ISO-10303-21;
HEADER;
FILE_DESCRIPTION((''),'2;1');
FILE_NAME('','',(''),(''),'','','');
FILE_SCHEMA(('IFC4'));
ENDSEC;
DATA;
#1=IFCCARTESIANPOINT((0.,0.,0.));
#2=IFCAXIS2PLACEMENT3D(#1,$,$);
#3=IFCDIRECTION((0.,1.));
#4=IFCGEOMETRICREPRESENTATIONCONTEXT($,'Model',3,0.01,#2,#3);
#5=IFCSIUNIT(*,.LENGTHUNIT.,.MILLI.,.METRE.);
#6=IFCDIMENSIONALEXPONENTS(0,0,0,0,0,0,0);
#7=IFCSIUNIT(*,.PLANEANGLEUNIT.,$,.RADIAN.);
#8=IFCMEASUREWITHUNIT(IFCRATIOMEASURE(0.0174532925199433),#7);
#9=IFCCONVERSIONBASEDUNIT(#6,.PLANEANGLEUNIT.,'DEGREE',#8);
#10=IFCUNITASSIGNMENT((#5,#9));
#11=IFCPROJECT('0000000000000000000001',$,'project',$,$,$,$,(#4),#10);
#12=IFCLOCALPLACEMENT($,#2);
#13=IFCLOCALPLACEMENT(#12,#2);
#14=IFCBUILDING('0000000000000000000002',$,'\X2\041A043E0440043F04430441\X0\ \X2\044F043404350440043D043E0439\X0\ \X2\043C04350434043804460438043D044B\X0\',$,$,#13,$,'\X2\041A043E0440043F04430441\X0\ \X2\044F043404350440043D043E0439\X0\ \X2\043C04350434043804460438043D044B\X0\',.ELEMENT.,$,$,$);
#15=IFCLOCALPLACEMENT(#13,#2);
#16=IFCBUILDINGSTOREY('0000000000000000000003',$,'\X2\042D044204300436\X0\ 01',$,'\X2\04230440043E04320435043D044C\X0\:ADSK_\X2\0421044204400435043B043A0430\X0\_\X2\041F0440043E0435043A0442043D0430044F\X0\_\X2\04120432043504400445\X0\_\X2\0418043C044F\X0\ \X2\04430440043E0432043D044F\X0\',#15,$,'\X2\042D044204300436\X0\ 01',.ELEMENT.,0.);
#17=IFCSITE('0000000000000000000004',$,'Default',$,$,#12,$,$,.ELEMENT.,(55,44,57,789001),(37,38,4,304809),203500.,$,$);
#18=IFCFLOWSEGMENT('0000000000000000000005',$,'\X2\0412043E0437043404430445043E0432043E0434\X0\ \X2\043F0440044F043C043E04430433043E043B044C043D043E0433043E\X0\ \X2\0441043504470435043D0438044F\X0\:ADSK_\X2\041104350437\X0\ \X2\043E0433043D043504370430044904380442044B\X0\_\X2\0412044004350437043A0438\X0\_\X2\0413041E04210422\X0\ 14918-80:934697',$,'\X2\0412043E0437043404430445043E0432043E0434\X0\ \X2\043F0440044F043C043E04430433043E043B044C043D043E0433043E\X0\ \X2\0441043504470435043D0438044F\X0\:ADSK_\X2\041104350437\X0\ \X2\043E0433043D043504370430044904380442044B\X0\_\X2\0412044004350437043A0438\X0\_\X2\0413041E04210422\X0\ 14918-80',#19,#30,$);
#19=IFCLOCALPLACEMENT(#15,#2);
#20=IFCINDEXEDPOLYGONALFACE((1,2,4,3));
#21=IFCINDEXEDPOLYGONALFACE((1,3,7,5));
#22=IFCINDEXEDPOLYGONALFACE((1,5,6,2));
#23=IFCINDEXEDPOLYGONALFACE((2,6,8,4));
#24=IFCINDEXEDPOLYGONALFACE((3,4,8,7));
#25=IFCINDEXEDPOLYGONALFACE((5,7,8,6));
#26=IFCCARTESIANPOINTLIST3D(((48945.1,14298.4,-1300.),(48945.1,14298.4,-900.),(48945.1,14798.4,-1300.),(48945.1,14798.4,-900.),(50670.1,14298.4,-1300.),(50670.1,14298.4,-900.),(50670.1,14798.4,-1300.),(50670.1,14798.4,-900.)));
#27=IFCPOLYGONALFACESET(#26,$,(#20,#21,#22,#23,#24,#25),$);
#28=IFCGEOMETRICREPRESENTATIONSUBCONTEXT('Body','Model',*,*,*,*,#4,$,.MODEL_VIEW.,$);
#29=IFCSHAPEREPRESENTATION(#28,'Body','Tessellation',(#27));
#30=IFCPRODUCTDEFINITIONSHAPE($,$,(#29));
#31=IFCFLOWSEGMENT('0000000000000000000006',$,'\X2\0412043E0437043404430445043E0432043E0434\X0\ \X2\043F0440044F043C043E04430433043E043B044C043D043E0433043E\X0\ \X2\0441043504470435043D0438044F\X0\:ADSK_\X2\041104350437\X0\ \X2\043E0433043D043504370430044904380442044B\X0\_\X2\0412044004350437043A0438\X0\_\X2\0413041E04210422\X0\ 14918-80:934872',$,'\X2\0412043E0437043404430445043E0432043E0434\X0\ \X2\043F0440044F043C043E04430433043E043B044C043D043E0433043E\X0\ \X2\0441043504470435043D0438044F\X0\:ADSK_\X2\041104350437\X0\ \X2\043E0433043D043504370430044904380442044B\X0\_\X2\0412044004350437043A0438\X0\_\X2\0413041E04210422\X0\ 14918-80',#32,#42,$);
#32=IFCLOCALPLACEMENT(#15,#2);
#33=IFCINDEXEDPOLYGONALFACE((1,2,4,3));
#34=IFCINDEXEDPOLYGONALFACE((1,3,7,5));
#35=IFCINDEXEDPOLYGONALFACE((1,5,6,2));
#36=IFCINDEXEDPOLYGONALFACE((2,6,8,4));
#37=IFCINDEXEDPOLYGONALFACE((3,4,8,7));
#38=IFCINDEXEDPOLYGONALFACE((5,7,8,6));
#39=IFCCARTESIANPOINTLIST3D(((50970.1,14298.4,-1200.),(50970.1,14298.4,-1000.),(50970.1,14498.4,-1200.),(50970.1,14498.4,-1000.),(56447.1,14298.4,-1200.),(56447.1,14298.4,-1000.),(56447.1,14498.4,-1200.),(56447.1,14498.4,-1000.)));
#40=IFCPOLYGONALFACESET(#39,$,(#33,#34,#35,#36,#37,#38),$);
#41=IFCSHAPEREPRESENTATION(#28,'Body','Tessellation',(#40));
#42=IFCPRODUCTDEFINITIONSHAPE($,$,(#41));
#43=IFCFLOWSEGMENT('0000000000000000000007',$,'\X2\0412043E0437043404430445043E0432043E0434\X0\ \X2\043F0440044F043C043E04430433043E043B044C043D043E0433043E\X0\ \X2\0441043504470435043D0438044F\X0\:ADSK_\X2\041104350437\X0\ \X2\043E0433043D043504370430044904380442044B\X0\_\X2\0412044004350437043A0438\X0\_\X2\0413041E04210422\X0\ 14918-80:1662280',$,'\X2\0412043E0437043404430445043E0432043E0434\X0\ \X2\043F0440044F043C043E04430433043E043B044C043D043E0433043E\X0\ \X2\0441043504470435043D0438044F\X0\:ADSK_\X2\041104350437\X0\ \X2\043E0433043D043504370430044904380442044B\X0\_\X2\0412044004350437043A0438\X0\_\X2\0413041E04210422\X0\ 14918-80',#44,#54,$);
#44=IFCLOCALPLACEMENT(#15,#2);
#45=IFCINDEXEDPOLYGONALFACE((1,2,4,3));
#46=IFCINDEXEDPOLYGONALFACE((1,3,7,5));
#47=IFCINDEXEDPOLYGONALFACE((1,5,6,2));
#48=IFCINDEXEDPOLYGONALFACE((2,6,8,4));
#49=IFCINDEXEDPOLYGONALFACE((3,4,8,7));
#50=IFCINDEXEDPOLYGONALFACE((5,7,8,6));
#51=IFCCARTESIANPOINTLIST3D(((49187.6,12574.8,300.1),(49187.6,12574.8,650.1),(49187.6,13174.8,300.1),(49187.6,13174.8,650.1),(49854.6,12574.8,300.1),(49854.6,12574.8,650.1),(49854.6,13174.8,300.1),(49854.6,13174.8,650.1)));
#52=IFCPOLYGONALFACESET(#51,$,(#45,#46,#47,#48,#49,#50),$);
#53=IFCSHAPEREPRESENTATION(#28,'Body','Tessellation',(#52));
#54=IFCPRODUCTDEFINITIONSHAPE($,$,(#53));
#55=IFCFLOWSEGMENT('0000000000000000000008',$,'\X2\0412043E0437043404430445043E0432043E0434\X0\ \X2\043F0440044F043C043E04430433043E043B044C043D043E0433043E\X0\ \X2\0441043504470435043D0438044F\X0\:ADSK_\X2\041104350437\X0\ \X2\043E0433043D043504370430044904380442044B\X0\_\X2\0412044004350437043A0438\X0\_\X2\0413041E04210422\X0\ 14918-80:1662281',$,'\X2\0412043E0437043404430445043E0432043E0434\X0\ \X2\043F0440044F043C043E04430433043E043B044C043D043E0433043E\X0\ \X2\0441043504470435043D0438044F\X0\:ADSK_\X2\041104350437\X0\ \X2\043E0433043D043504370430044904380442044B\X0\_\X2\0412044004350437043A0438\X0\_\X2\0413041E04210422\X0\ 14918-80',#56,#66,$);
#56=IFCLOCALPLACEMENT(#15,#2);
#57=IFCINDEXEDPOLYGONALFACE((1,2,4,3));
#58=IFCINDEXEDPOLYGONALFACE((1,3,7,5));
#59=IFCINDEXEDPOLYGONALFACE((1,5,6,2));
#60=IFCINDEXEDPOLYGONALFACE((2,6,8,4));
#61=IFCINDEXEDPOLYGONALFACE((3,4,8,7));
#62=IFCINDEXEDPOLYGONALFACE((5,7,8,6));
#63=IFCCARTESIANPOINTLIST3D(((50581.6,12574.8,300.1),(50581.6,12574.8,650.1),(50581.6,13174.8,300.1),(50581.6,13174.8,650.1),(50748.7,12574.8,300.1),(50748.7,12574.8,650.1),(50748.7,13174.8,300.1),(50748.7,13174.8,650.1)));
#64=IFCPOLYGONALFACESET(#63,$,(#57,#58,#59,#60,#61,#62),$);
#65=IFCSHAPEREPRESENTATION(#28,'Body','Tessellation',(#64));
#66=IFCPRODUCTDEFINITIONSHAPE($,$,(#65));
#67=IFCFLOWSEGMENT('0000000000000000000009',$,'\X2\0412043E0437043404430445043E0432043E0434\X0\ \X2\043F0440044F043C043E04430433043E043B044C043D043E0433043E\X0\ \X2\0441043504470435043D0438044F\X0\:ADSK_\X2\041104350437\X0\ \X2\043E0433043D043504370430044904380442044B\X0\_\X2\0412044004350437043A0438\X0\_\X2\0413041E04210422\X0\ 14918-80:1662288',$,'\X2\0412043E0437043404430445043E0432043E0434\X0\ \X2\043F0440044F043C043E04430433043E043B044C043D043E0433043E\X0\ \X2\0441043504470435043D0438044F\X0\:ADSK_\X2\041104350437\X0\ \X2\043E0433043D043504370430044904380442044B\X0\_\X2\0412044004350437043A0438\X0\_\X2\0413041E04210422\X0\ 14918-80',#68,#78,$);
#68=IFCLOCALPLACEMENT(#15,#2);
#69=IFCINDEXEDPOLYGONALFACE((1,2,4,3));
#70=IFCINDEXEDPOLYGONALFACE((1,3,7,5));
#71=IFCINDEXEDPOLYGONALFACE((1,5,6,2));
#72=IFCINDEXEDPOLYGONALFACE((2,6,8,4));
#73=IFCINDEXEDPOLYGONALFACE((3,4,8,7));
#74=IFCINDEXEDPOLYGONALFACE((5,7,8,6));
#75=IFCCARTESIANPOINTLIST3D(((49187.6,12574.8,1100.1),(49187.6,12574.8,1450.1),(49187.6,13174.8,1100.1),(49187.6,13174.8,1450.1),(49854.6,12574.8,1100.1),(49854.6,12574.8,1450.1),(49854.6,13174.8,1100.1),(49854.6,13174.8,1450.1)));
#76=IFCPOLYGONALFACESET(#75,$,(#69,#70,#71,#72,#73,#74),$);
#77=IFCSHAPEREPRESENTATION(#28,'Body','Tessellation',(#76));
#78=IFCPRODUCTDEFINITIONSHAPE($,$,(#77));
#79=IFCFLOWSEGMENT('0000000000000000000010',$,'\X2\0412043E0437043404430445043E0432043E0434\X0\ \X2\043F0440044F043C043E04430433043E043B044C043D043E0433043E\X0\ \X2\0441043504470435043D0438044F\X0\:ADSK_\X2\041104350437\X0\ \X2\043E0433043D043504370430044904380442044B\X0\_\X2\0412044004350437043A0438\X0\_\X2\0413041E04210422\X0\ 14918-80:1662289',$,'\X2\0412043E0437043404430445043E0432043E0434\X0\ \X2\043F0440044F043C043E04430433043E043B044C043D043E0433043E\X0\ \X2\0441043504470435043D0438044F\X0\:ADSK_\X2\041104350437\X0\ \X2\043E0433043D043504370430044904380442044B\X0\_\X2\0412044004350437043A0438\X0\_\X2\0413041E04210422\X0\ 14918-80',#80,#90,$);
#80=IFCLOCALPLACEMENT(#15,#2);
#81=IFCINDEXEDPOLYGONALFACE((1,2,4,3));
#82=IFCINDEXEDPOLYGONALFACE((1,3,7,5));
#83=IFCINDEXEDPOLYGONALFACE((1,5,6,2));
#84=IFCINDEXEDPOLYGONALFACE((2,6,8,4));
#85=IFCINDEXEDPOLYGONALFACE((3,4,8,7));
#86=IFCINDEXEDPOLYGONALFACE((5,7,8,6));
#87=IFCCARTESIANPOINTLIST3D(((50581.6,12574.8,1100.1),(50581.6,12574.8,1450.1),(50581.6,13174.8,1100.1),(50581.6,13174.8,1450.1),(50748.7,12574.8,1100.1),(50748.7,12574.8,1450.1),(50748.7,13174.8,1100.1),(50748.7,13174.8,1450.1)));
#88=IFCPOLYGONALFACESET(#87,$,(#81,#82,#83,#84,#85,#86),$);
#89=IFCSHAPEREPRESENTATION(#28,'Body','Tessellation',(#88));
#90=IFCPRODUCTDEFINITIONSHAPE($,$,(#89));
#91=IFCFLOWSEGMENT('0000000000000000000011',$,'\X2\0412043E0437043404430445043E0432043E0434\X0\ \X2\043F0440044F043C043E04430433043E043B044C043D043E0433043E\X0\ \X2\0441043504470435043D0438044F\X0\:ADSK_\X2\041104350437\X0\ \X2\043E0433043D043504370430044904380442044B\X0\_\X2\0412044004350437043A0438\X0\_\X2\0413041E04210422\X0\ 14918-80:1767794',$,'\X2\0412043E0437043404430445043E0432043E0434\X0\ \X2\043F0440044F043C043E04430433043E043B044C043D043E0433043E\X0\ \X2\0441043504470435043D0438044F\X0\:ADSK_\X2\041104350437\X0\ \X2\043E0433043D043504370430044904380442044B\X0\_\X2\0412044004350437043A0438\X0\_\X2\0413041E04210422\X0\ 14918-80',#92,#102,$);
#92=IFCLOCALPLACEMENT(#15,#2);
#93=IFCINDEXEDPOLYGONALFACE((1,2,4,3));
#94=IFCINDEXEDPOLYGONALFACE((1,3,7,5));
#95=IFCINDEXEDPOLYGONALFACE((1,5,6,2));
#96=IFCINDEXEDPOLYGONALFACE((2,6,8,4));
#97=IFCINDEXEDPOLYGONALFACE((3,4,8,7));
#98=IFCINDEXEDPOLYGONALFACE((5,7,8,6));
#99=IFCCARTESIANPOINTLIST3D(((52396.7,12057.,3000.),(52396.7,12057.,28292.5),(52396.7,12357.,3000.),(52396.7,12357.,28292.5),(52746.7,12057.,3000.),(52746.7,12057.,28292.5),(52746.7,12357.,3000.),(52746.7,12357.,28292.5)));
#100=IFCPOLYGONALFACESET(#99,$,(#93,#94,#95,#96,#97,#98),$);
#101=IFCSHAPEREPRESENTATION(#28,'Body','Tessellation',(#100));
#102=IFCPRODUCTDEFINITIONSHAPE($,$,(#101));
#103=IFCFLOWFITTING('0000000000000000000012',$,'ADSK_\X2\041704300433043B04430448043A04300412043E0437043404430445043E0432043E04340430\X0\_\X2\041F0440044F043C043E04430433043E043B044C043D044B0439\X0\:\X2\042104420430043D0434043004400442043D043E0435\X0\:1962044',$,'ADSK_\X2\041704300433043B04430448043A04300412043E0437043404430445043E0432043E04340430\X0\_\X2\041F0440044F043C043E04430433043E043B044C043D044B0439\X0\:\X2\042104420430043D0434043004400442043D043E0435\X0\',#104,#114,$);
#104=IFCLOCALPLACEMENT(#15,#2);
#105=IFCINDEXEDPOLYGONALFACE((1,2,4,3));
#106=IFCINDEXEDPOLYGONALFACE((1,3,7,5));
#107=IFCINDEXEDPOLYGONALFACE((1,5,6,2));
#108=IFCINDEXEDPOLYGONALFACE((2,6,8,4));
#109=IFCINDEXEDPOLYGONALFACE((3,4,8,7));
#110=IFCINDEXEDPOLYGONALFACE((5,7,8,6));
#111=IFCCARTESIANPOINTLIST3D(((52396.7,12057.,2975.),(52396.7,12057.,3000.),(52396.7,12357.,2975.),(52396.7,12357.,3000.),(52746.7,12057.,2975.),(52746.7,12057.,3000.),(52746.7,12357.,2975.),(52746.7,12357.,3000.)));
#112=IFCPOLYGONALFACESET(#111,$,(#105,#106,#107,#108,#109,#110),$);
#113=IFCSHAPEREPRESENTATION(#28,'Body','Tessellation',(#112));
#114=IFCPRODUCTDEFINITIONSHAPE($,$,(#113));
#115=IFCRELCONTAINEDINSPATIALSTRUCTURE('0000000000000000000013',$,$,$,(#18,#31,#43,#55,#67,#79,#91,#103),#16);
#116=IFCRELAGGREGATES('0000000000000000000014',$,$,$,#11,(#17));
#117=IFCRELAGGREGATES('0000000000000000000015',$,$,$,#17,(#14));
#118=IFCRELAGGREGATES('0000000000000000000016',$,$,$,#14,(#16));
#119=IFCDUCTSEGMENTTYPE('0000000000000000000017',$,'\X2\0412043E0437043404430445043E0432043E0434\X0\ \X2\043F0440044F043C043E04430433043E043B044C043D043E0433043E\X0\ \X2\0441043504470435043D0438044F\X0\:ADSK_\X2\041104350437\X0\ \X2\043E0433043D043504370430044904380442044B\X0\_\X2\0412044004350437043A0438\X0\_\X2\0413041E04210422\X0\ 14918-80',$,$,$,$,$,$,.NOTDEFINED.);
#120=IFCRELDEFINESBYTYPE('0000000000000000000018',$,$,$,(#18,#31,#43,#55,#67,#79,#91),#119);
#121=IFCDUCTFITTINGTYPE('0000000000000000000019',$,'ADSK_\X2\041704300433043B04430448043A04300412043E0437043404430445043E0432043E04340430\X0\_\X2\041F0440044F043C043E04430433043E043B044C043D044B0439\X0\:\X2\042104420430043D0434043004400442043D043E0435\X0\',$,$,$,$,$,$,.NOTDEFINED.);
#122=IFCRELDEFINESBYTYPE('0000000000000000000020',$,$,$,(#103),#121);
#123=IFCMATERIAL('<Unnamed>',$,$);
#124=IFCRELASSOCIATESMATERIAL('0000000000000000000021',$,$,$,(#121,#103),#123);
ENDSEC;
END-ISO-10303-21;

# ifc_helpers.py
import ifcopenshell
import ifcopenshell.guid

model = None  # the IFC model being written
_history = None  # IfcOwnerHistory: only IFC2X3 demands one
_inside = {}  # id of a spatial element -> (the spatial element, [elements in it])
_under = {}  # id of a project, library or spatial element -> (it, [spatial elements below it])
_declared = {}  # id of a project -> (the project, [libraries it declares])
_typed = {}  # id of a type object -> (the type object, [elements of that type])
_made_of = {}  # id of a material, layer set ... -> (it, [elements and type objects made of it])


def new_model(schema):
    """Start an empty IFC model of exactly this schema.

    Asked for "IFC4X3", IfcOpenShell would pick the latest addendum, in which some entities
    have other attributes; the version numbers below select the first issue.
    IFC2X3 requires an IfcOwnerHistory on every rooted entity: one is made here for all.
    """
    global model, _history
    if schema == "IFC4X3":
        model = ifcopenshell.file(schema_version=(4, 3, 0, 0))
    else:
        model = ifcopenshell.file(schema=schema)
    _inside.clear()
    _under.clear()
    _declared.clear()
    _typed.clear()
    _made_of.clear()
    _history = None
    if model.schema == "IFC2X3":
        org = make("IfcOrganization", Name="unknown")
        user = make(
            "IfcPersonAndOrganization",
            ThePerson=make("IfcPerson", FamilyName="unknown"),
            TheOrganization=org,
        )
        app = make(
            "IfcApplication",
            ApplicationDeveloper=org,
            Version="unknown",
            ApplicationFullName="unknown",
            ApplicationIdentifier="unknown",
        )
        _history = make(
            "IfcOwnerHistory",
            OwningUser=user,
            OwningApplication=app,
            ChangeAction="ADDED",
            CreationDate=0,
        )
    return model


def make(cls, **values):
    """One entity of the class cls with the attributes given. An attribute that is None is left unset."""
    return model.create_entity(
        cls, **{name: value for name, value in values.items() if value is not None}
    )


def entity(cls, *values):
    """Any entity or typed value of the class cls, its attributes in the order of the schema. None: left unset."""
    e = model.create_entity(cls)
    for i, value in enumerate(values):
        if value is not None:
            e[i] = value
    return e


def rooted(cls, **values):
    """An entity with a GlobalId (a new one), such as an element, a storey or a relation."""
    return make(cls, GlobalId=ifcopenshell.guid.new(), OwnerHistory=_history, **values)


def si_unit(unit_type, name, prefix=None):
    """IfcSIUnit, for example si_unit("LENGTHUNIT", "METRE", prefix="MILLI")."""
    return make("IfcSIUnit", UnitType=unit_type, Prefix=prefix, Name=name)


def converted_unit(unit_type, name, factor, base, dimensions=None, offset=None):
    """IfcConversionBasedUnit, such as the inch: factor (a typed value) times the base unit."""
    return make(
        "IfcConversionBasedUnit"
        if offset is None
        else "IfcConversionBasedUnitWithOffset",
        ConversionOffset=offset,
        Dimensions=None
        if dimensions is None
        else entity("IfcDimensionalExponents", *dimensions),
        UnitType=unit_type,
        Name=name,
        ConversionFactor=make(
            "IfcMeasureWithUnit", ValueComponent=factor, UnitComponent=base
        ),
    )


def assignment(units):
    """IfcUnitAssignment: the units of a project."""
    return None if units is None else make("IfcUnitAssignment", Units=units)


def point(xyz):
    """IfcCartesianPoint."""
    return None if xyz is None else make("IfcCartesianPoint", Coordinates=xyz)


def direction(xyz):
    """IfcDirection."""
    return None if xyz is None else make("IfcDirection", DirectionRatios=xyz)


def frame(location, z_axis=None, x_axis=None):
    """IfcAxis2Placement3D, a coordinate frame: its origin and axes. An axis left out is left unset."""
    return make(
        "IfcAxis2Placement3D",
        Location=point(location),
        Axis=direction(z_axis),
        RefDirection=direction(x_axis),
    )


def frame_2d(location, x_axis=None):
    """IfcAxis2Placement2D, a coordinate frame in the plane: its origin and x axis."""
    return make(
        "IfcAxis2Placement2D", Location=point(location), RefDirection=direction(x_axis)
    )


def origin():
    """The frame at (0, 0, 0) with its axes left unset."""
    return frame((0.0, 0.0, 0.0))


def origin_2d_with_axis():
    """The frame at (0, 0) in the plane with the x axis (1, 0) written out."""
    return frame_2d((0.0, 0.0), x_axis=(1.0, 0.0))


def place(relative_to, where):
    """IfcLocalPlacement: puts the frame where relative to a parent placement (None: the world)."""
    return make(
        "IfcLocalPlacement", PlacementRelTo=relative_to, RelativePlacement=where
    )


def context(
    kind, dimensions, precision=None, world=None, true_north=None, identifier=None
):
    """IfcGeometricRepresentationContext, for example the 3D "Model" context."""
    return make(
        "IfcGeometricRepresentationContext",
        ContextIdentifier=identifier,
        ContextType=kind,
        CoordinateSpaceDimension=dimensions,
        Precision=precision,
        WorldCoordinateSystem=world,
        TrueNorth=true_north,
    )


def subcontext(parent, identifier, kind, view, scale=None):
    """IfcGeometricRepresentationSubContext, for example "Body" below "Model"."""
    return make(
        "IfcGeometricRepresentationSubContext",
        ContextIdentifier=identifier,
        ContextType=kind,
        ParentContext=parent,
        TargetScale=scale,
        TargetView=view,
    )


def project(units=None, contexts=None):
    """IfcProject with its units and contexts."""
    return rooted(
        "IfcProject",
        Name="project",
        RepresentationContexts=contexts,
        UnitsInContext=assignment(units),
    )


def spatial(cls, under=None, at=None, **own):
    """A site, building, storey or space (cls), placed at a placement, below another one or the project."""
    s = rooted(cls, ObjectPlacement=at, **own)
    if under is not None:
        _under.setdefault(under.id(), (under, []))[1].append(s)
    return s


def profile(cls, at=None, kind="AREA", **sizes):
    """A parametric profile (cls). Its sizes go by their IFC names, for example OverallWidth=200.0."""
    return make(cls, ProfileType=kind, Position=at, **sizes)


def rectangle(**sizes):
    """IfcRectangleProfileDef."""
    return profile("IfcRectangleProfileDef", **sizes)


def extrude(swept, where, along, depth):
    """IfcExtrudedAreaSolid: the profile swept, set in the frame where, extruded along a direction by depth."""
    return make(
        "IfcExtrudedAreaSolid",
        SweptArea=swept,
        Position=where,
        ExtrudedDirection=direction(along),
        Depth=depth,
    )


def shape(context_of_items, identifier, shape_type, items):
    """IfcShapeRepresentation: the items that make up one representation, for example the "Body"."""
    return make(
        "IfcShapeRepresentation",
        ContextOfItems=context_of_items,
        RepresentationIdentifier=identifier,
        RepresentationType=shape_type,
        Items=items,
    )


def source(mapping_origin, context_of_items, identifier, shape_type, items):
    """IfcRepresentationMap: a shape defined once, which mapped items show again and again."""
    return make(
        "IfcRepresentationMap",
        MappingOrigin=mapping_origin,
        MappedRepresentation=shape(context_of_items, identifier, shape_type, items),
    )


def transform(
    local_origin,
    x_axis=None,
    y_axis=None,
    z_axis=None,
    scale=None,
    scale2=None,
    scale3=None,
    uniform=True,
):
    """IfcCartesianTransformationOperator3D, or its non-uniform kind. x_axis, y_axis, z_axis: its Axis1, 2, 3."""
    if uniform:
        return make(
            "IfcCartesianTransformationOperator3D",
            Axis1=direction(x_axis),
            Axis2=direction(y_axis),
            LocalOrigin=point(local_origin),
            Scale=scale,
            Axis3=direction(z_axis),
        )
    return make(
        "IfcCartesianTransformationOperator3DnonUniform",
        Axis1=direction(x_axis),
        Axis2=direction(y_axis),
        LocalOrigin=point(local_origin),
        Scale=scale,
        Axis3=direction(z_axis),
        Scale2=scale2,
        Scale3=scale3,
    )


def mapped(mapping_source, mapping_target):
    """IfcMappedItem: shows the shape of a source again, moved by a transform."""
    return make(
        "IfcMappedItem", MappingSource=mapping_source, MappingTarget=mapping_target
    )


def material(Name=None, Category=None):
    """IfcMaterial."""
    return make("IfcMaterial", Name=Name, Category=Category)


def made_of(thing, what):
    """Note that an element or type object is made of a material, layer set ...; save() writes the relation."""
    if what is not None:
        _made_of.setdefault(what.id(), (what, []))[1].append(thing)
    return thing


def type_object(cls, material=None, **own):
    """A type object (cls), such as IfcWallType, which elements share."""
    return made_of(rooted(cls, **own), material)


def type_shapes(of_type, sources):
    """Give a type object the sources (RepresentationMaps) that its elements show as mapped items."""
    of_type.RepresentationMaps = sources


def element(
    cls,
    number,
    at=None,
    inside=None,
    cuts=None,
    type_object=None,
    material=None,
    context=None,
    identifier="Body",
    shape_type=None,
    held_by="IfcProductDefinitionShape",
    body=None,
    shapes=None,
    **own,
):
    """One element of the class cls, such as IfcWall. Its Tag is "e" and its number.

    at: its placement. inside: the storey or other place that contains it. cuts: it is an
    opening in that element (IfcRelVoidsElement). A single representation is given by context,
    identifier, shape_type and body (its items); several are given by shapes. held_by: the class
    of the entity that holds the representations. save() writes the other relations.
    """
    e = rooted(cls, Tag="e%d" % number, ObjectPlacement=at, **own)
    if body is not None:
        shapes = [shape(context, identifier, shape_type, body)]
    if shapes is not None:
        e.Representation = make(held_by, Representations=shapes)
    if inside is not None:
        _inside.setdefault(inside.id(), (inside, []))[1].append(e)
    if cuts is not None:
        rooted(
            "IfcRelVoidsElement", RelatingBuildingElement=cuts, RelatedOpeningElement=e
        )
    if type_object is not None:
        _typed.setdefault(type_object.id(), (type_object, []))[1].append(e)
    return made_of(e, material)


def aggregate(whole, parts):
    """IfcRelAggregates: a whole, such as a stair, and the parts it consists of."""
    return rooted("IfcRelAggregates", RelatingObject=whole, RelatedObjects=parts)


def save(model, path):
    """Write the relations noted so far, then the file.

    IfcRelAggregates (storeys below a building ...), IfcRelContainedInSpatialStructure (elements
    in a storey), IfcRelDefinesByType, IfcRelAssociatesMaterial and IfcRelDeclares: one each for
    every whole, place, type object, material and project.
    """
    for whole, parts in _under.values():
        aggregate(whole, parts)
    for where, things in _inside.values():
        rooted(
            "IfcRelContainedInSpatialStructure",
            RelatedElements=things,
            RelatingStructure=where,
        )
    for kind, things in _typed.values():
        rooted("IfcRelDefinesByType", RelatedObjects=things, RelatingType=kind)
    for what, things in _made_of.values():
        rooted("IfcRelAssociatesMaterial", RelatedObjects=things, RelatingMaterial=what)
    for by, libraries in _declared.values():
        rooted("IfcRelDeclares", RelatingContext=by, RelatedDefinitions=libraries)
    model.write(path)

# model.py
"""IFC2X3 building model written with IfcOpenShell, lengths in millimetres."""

from ifc_helpers import new_model, entity, si_unit, converted_unit, direction, frame, origin, origin_2d_with_axis, place, context, subcontext, project, spatial, rectangle, extrude, source, transform, mapped, material, type_object, type_shapes, element, save


model = new_model("IFC2X3")

# Units and contexts
model_context = context("Model", 3, precision=0.01, world=origin(), true_north=direction((0.0, 1.0)))
body_context = subcontext(model_context, "Body", "Model", "MODEL_VIEW")
ifc_project = project(units=[si_unit("LENGTHUNIT", "METRE", prefix="MILLI"), converted_unit("PLANEANGLEUNIT", "DEGREE", entity("IfcRatioMeasure", 0.0174532925199433), si_unit("PLANEANGLEUNIT", "RADIAN"), dimensions=[0, 0, 0, 0, 0, 0, 0])], contexts=[model_context])

# Site, building, storey
site_placement = place(None, origin())
site = spatial("IfcSite", under=ifc_project, at=site_placement, Name="Default", CompositionType="ELEMENT", RefLatitude=(55, 44, 57, 789001), RefLongitude=(37, 38, 4, 304809), RefElevation=203500.0)
building_placement = place(site_placement, origin())
building = spatial("IfcBuilding", under=site, at=building_placement, Name="Корпус ядерной медицины", LongName="Корпус ядерной медицины", CompositionType="ELEMENT")
storey_placement = place(building_placement, origin())
storey = spatial("IfcBuildingStorey", under=building, at=storey_placement, Name="Этаж 01", ObjectType="Уровень:ADSK_Стрелка_Проектная_Вверх_Имя уровня", LongName="Этаж 01", CompositionType="ELEMENT", Elevation=0.0)

# Flow segments
duct_segment_type_1 = type_object("IfcDuctSegmentType", Name="Воздуховод прямоугольного сечения:ADSK_Без огнезащиты_Врезки_ГОСТ 14918-80", PredefinedType="NOTDEFINED")
flow_segment_1_placement = place(storey_placement, frame((48945.1, 14298.4, -1300.0)))
element("IfcFlowSegment", 1, at=flow_segment_1_placement, inside=storey, type_object=duct_segment_type_1, Name="Воздуховод прямоугольного сечения:ADSK_Без огнезащиты_Врезки_ГОСТ 14918-80:934697", ObjectType="Воздуховод прямоугольного сечения:ADSK_Без огнезащиты_Врезки_ГОСТ 14918-80", context=body_context, shape_type="SweptSolid", body=[
    extrude(rectangle(XDim=1725.0, YDim=500.0, at=origin_2d_with_axis()), frame((862.5, 250.0, 0.0)), (0.0, 0.0, 1.0), 400.0),
])
flow_segment_2_placement = place(storey_placement, frame((50970.1, 14298.4, -1200.0)))
element("IfcFlowSegment", 2, at=flow_segment_2_placement, inside=storey, type_object=duct_segment_type_1, Name="Воздуховод прямоугольного сечения:ADSK_Без огнезащиты_Врезки_ГОСТ 14918-80:934872", ObjectType="Воздуховод прямоугольного сечения:ADSK_Без огнезащиты_Врезки_ГОСТ 14918-80", context=body_context, shape_type="SweptSolid", body=[
    extrude(rectangle(XDim=5477.0, YDim=200.0, at=origin_2d_with_axis()), frame((2738.5, 100.0, 0.0), z_axis=(0.0, 0.0, 1.0), x_axis=(-1.0, 0.0, 0.0)), (0.0, 0.0, 1.0), 200.0),
])
flow_segment_3_placement = place(storey_placement, frame((49187.6, 12574.8, 300.1)))
element("IfcFlowSegment", 3, at=flow_segment_3_placement, inside=storey, type_object=duct_segment_type_1, Name="Воздуховод прямоугольного сечения:ADSK_Без огнезащиты_Врезки_ГОСТ 14918-80:1662280", ObjectType="Воздуховод прямоугольного сечения:ADSK_Без огнезащиты_Врезки_ГОСТ 14918-80", context=body_context, shape_type="SweptSolid", body=[
    extrude(rectangle(XDim=667.0, YDim=600.0, at=origin_2d_with_axis()), frame((333.5, 300.0, 0.0), z_axis=(0.0, 0.0, 1.0), x_axis=(-1.0, 0.0, 0.0)), (0.0, 0.0, 1.0), 350.0),
])
flow_segment_4_placement = place(storey_placement, frame((50581.6, 12574.8, 300.1)))
element("IfcFlowSegment", 4, at=flow_segment_4_placement, inside=storey, type_object=duct_segment_type_1, Name="Воздуховод прямоугольного сечения:ADSK_Без огнезащиты_Врезки_ГОСТ 14918-80:1662281", ObjectType="Воздуховод прямоугольного сечения:ADSK_Без огнезащиты_Врезки_ГОСТ 14918-80", context=body_context, shape_type="SweptSolid", body=[
    extrude(rectangle(XDim=167.1, YDim=600.0, at=origin_2d_with_axis()), frame((83.6, 300.0, 0.0)), (0.0, 0.0, 1.0), 350.0),
])
flow_segment_5_placement = place(storey_placement, frame((49187.6, 12574.8, 1100.1)))
element("IfcFlowSegment", 5, at=flow_segment_5_placement, inside=storey, type_object=duct_segment_type_1, Name="Воздуховод прямоугольного сечения:ADSK_Без огнезащиты_Врезки_ГОСТ 14918-80:1662288", ObjectType="Воздуховод прямоугольного сечения:ADSK_Без огнезащиты_Врезки_ГОСТ 14918-80", context=body_context, shape_type="SweptSolid", body=[
    extrude(rectangle(XDim=667.0, YDim=600.0, at=origin_2d_with_axis()), frame((333.5, 300.0, 0.0), z_axis=(0.0, 0.0, 1.0), x_axis=(-1.0, 0.0, 0.0)), (0.0, 0.0, 1.0), 350.0),
])
flow_segment_6_placement = place(storey_placement, frame((50581.6, 12574.8, 1100.1)))
element("IfcFlowSegment", 6, at=flow_segment_6_placement, inside=storey, type_object=duct_segment_type_1, Name="Воздуховод прямоугольного сечения:ADSK_Без огнезащиты_Врезки_ГОСТ 14918-80:1662289", ObjectType="Воздуховод прямоугольного сечения:ADSK_Без огнезащиты_Врезки_ГОСТ 14918-80", context=body_context, shape_type="SweptSolid", body=[
    extrude(rectangle(XDim=167.1, YDim=600.0, at=origin_2d_with_axis()), frame((83.6, 300.0, 0.0)), (0.0, 0.0, 1.0), 350.0),
])
flow_segment_7_placement = place(storey_placement, frame((52396.7, 12057.0, 3000.0)))
element("IfcFlowSegment", 7, at=flow_segment_7_placement, inside=storey, type_object=duct_segment_type_1, Name="Воздуховод прямоугольного сечения:ADSK_Без огнезащиты_Врезки_ГОСТ 14918-80:1767794", ObjectType="Воздуховод прямоугольного сечения:ADSK_Без огнезащиты_Врезки_ГОСТ 14918-80", context=body_context, shape_type="SweptSolid", body=[
    extrude(rectangle(XDim=300.0, YDim=350.0, at=origin_2d_with_axis()), frame((175.0, 150.0, 0.0), z_axis=(0.0, 0.0, 1.0), x_axis=(0.0, -1.0, 0.0)), (0.0, 0.0, 1.0), 25292.5),
])

# Flow fitting
ifc_material = material(Name="<Unnamed>")
duct_fitting_type = type_object("IfcDuctFittingType", Name="ADSK_ЗаглушкаВоздуховода_Прямоугольный:Стандартное", PredefinedType="NOTDEFINED", material=ifc_material)
shared_shape = source(origin(), body_context, "Body", "SweptSolid", [
    extrude(rectangle(XDim=25.0, YDim=300.0, at=origin_2d_with_axis()), frame((12.5, 0.0, -175.0)), (0.0, 0.0, 1.0), 350.0),
])
type_shapes(duct_fitting_type, [shared_shape])
flow_fitting_placement = place(storey_placement, frame((52571.7, 12207.0, 3000.0), z_axis=(-1.0, 0.0, 0.0), x_axis=(0.0, 0.0, -1.0)))
element("IfcFlowFitting", 8, at=flow_fitting_placement, inside=storey, type_object=duct_fitting_type, material=ifc_material, Name="ADSK_ЗаглушкаВоздуховода_Прямоугольный:Стандартное:1962044", ObjectType="ADSK_ЗаглушкаВоздуховода_Прямоугольный:Стандартное", context=body_context, shape_type="MappedRepresentation", body=[
    mapped(shared_shape, transform((0.0, 0.0, 0.0), scale=1.0)),
])

save(model, "model.ifc")
